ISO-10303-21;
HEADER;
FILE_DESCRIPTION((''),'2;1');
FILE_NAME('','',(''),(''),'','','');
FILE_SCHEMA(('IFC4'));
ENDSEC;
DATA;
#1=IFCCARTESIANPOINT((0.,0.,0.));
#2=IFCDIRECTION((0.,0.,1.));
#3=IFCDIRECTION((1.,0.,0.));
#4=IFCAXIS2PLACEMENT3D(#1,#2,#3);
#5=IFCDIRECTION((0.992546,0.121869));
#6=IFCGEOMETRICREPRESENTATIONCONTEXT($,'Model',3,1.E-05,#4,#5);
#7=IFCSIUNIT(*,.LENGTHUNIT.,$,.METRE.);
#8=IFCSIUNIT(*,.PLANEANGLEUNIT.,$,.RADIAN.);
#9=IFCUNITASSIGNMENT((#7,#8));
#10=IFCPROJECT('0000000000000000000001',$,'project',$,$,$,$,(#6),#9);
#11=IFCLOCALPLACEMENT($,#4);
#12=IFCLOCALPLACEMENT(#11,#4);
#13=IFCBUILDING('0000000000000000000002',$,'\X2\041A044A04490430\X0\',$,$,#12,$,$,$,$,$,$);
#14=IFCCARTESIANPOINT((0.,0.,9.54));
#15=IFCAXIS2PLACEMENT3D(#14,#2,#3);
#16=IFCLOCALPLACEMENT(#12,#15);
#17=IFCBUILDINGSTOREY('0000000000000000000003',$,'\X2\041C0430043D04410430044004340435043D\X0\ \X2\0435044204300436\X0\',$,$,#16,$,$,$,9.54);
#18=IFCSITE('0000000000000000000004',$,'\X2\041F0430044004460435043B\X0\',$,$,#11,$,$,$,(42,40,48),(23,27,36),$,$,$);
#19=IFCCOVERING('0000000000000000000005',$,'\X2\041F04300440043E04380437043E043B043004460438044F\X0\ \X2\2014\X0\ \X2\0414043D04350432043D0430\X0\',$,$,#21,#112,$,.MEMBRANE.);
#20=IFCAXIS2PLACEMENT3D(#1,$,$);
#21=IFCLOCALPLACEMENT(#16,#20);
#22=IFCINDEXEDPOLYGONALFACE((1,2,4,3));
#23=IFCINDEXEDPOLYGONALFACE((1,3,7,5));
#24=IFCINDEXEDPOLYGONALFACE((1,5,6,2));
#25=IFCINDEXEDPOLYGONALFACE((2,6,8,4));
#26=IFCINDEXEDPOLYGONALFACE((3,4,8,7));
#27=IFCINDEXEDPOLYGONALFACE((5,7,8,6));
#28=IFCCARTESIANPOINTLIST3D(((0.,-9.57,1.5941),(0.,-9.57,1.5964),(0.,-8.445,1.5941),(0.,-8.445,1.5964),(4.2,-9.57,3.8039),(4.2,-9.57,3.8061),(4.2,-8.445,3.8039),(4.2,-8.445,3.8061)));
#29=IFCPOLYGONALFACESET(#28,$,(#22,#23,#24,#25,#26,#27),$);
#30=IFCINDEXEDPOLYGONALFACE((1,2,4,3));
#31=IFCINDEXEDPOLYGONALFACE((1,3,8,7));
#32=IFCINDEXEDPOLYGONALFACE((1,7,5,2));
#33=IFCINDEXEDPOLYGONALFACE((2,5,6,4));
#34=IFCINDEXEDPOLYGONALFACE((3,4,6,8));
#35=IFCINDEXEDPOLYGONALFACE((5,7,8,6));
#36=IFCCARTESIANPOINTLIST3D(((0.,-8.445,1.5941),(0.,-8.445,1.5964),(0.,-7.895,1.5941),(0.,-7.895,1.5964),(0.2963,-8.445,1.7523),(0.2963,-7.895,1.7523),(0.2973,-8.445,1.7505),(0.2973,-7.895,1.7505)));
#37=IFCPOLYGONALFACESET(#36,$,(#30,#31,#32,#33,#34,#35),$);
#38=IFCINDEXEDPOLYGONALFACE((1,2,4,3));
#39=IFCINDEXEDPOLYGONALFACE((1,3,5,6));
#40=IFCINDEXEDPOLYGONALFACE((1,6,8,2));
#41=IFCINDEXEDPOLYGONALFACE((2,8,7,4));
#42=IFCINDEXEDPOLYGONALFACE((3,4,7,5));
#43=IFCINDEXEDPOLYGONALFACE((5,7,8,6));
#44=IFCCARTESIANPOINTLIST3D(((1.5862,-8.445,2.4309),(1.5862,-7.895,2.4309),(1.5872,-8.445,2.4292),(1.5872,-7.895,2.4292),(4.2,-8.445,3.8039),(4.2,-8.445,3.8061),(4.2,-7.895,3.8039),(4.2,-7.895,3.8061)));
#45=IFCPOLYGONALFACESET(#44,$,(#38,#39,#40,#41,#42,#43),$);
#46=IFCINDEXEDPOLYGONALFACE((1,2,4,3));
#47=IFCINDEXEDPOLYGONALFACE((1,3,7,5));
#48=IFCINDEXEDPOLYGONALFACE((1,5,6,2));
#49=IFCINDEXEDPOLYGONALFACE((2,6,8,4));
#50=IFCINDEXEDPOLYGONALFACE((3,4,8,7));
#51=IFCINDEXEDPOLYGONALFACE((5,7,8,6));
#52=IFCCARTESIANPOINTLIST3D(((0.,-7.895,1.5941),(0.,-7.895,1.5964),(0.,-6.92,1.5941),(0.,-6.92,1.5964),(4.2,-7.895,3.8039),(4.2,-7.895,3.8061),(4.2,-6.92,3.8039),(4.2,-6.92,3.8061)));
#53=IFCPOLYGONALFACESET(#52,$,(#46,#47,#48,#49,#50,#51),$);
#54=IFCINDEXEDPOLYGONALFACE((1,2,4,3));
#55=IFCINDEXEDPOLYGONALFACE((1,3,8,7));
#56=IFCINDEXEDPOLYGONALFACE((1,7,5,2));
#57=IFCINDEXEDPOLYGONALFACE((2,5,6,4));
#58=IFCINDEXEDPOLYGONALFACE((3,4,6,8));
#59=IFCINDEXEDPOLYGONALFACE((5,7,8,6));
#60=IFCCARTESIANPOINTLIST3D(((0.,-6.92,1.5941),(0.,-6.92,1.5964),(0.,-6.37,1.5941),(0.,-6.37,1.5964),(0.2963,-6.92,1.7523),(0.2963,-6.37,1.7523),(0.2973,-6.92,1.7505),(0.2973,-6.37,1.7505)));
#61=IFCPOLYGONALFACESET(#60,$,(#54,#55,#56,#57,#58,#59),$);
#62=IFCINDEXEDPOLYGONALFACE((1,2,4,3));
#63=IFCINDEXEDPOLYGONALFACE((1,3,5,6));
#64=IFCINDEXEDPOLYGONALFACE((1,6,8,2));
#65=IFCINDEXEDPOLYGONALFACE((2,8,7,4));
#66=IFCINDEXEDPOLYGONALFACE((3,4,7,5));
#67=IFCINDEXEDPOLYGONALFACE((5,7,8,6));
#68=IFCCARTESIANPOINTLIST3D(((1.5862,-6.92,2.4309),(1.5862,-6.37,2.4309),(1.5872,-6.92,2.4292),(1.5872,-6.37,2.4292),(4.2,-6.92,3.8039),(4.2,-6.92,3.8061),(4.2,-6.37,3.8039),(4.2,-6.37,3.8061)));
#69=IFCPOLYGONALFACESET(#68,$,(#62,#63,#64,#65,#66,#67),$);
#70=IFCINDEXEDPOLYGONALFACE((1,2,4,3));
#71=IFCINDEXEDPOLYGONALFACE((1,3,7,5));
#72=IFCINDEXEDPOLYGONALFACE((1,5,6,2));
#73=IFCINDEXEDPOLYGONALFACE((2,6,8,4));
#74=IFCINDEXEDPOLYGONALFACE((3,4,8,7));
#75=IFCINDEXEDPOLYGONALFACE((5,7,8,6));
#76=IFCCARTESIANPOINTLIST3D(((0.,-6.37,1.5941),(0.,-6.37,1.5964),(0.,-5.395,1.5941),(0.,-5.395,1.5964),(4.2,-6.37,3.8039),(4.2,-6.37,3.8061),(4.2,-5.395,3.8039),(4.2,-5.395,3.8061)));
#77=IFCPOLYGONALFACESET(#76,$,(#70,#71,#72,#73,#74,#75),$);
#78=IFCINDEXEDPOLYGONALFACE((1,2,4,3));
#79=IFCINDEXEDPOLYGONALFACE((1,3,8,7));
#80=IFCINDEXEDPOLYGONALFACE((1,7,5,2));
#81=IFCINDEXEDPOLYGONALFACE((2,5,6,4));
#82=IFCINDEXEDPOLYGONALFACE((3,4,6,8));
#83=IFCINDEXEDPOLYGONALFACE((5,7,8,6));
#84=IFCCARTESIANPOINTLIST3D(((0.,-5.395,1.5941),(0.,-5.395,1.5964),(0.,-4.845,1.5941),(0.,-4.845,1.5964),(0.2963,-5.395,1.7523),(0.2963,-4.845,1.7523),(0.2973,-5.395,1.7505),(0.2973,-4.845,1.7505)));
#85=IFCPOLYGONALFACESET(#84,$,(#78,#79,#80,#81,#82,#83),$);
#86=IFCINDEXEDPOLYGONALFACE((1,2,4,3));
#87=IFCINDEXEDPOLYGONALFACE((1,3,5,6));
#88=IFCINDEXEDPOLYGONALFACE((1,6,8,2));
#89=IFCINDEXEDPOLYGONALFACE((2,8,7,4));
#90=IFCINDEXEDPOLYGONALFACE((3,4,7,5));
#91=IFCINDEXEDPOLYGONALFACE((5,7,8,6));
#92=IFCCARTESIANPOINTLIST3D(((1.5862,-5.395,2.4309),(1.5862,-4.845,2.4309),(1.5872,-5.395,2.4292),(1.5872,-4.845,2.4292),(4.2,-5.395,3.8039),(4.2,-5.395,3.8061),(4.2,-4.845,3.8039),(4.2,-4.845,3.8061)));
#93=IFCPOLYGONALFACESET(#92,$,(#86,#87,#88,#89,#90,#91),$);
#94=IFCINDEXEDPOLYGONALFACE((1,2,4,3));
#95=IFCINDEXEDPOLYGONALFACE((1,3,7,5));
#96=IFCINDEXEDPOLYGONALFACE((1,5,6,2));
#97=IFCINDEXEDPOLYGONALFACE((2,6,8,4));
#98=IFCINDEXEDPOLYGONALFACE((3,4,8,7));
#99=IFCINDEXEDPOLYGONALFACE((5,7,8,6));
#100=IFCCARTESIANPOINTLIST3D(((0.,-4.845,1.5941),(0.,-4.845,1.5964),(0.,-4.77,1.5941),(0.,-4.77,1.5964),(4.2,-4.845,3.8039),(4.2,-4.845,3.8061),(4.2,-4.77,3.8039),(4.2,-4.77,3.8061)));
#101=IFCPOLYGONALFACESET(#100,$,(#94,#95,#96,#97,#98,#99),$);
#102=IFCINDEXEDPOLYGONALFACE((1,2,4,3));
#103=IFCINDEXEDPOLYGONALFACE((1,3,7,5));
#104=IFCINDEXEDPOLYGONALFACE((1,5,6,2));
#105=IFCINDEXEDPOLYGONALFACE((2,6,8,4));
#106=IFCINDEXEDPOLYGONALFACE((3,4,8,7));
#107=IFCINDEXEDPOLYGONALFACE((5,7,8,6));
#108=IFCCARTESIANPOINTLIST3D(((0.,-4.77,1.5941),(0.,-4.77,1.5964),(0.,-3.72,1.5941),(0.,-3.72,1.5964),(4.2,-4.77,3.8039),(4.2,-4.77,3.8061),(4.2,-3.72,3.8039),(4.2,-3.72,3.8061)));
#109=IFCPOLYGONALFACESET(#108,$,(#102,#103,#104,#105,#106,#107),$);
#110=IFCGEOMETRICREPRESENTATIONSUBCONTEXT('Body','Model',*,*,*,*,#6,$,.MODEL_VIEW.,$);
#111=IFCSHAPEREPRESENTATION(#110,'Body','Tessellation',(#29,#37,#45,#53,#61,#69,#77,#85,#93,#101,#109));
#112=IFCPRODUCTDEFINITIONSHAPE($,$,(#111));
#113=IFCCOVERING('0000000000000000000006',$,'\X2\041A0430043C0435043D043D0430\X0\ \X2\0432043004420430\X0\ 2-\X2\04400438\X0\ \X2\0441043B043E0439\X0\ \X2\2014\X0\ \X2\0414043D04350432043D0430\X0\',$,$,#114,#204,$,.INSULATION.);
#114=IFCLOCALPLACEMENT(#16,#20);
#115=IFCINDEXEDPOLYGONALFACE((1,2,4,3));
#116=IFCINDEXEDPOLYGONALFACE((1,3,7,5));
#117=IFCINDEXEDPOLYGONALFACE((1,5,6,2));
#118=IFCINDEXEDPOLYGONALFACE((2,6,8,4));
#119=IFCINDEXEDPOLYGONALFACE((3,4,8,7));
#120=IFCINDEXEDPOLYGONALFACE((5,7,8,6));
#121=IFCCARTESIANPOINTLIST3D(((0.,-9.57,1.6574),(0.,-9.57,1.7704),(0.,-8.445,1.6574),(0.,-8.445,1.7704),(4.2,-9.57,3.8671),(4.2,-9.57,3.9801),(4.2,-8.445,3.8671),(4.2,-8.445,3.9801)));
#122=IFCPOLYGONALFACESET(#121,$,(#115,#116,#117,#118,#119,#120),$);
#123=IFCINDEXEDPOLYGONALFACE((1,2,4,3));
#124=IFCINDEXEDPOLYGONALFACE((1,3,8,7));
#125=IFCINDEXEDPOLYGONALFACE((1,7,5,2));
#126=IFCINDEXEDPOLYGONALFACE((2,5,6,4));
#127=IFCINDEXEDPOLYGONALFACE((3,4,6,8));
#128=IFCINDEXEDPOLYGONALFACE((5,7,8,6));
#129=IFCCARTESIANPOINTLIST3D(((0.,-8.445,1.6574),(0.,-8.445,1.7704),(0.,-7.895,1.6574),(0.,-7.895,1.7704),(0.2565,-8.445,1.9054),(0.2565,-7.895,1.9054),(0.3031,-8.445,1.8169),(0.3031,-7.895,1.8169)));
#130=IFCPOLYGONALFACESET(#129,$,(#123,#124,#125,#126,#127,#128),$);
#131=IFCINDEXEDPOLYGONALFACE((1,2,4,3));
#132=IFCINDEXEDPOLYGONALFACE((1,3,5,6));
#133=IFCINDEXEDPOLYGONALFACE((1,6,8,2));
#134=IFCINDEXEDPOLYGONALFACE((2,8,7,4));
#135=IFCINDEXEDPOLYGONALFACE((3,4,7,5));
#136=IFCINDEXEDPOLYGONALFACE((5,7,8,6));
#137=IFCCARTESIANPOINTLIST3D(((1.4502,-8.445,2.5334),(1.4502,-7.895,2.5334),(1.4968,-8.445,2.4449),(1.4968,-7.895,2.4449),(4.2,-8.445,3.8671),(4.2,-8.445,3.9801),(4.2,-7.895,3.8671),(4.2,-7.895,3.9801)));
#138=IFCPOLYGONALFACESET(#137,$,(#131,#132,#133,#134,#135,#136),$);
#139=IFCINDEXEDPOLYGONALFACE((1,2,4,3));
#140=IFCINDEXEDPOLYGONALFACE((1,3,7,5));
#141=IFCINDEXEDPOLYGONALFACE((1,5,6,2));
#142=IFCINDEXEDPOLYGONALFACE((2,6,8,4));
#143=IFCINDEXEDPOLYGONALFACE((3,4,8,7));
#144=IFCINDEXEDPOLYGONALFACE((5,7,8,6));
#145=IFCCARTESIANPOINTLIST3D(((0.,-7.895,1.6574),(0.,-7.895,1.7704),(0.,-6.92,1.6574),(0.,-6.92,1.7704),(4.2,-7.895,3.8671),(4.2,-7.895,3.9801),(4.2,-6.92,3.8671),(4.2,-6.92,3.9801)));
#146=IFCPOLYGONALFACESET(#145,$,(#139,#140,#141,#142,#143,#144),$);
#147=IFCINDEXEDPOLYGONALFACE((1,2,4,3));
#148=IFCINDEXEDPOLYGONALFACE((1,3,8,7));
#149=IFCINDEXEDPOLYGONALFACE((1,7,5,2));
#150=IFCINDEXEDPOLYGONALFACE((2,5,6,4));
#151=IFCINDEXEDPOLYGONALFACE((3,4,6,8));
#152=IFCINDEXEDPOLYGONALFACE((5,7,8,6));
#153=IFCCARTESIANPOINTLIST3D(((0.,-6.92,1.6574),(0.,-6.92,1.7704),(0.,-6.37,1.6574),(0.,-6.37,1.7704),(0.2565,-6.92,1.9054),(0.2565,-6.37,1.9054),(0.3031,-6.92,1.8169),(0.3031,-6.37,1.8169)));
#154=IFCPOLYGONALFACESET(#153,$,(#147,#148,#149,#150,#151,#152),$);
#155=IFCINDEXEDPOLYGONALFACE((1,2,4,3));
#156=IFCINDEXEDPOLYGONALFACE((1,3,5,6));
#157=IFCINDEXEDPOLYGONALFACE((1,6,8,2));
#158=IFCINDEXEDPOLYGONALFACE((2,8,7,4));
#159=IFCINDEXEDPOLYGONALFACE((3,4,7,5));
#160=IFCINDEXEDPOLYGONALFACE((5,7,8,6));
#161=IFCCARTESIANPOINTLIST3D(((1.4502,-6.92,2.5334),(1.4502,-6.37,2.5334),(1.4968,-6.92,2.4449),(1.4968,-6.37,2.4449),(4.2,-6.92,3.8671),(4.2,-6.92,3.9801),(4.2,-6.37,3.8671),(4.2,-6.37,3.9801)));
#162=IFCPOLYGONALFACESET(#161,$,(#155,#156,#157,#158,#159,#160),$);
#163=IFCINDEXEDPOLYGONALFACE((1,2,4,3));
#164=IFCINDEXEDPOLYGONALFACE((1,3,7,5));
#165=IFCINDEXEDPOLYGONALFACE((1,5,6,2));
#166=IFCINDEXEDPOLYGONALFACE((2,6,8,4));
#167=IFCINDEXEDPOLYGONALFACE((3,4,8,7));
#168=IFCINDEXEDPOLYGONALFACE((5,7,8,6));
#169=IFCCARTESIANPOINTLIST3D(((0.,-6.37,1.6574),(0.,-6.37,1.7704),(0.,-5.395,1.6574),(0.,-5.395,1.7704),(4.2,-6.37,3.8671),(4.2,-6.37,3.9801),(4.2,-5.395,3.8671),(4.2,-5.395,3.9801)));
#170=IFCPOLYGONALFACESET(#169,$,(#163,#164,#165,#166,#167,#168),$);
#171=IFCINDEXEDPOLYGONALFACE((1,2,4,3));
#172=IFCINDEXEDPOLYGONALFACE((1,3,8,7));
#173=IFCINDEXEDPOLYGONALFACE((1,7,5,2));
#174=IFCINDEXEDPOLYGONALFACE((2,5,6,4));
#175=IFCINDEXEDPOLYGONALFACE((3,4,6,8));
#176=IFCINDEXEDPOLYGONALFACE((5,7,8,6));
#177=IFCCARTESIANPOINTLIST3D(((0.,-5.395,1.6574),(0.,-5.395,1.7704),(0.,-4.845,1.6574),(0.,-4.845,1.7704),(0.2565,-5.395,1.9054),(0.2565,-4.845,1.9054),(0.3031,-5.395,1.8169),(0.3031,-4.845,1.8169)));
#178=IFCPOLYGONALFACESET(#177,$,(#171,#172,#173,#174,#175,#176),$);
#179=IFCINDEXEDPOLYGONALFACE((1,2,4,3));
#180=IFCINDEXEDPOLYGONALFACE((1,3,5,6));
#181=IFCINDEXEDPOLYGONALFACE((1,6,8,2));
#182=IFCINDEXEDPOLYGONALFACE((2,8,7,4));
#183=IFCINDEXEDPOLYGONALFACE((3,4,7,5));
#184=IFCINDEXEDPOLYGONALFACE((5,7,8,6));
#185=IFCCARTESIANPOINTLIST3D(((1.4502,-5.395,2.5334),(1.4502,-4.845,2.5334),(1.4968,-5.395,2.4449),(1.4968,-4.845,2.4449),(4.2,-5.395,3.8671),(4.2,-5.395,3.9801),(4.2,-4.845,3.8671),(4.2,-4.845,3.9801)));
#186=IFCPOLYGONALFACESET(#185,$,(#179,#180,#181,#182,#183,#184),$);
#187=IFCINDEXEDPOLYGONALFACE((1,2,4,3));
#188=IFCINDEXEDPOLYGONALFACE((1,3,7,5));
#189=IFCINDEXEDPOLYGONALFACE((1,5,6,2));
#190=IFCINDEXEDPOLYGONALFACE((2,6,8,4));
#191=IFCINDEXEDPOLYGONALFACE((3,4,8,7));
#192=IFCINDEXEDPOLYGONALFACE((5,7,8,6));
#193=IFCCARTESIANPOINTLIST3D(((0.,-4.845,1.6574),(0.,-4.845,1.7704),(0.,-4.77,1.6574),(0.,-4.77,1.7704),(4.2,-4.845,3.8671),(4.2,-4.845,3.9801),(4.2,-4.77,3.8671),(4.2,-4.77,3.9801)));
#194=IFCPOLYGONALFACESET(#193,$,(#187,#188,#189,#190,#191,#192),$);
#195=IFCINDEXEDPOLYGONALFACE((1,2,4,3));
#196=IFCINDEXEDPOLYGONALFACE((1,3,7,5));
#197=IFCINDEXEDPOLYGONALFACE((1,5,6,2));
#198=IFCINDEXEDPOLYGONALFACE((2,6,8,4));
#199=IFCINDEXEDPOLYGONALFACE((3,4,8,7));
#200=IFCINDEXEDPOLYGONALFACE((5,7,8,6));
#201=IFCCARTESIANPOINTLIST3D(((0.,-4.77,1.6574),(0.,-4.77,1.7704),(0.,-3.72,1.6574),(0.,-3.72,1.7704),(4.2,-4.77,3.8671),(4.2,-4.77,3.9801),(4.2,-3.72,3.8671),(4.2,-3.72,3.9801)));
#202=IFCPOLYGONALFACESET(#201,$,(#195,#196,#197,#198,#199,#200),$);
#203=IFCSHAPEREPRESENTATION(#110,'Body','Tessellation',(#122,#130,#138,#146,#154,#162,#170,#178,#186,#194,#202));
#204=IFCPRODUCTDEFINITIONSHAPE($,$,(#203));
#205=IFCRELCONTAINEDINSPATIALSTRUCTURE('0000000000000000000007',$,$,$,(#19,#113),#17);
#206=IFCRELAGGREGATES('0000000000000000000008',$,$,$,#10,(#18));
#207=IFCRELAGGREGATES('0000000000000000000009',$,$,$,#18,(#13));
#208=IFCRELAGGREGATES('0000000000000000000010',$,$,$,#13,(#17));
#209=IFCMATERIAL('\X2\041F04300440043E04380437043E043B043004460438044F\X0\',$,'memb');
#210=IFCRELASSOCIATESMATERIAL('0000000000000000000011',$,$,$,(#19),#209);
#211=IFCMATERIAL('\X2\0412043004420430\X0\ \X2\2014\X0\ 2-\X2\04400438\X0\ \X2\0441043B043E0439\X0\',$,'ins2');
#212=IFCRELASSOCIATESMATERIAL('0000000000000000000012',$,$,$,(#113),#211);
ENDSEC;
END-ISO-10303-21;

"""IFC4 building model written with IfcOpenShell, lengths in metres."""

from ifc_helpers import new_model, si_unit, direction, frame, origin_with_axes, place, context, subcontext, project, spatial, polyline, outline, extrude, material, element, save


model = new_model("IFC4")

# Units and contexts
model_context = context("Model", 3, precision=1e-05, world=origin_with_axes(), true_north=direction((0.992546, 0.121869)))
body_context = subcontext(model_context, "Body", "Model", "MODEL_VIEW")
ifc_project = project(units=[si_unit("LENGTHUNIT", "METRE"), si_unit("PLANEANGLEUNIT", "RADIAN")], contexts=[model_context])

# Site, building, storey
site_placement = place(None, origin_with_axes())
site = spatial("IfcSite", under=ifc_project, at=site_placement, Name="Парцел", RefLatitude=(42, 40, 48), RefLongitude=(23, 27, 36))
building_placement = place(site_placement, origin_with_axes())
building = spatial("IfcBuilding", under=site, at=building_placement, Name="Къща")
storey_placement = place(building_placement, frame((0.0, 0.0, 9.54), z_axis=(0.0, 0.0, 1.0), x_axis=(1.0, 0.0, 0.0)))
storey = spatial("IfcBuildingStorey", under=building, at=storey_placement, Name="Мансарден етаж", Elevation=9.54)

# Coverings
ifc_material_1 = material(Name="Пароизолация", Category="memb")
covering_1_placement = place(storey_placement, origin_with_axes())
element("IfcCovering", 1, at=covering_1_placement, inside=storey, material=ifc_material_1, Name="Пароизолация — Дневна", PredefinedType="MEMBRANE", context=body_context, shape_type="SweptSolid", body=[
    extrude(outline(polyline([(0.0, -1.5941), (4.2, -3.8039), (4.2, -3.8061), (0.0, -1.5964), (0.0, -1.5941)])), frame((0.0, -9.57, 0.0), z_axis=(0.0, 1.0, 0.0), x_axis=(1.0, 0.0, 0.0)), (0.0, 0.0, 1.0), 1.125),
    extrude(outline(polyline([(0.0, -1.5941), (0.2973, -1.7505), (0.2963, -1.7523), (0.0, -1.5964), (0.0, -1.5941)])), frame((0.0, -8.445, 0.0), z_axis=(0.0, 1.0, 0.0), x_axis=(1.0, 0.0, 0.0)), (0.0, 0.0, 1.0), 0.55),
    extrude(outline(polyline([(1.5872, -2.4292), (4.2, -3.8039), (4.2, -3.8061), (1.5862, -2.4309), (1.5872, -2.4292)])), frame((0.0, -8.445, 0.0), z_axis=(0.0, 1.0, 0.0), x_axis=(1.0, 0.0, 0.0)), (0.0, 0.0, 1.0), 0.55),
    extrude(outline(polyline([(0.0, -1.5941), (4.2, -3.8039), (4.2, -3.8061), (0.0, -1.5964), (0.0, -1.5941)])), frame((0.0, -7.895, 0.0), z_axis=(0.0, 1.0, 0.0), x_axis=(1.0, 0.0, 0.0)), (0.0, 0.0, 1.0), 0.975),
    extrude(outline(polyline([(0.0, -1.5941), (0.2973, -1.7505), (0.2963, -1.7523), (0.0, -1.5964), (0.0, -1.5941)])), frame((0.0, -6.92, 0.0), z_axis=(0.0, 1.0, 0.0), x_axis=(1.0, 0.0, 0.0)), (0.0, 0.0, 1.0), 0.55),
    extrude(outline(polyline([(1.5872, -2.4292), (4.2, -3.8039), (4.2, -3.8061), (1.5862, -2.4309), (1.5872, -2.4292)])), frame((0.0, -6.92, 0.0), z_axis=(0.0, 1.0, 0.0), x_axis=(1.0, 0.0, 0.0)), (0.0, 0.0, 1.0), 0.55),
    extrude(outline(polyline([(0.0, -1.5941), (4.2, -3.8039), (4.2, -3.8061), (0.0, -1.5964), (0.0, -1.5941)])), frame((0.0, -6.37, 0.0), z_axis=(0.0, 1.0, 0.0), x_axis=(1.0, 0.0, 0.0)), (0.0, 0.0, 1.0), 0.975),
    extrude(outline(polyline([(0.0, -1.5941), (0.2973, -1.7505), (0.2963, -1.7523), (0.0, -1.5964), (0.0, -1.5941)])), frame((0.0, -5.395, 0.0), z_axis=(0.0, 1.0, 0.0), x_axis=(1.0, 0.0, 0.0)), (0.0, 0.0, 1.0), 0.55),
    extrude(outline(polyline([(1.5872, -2.4292), (4.2, -3.8039), (4.2, -3.8061), (1.5862, -2.4309), (1.5872, -2.4292)])), frame((0.0, -5.395, 0.0), z_axis=(0.0, 1.0, 0.0), x_axis=(1.0, 0.0, 0.0)), (0.0, 0.0, 1.0), 0.55),
    extrude(outline(polyline([(0.0, -1.5941), (4.2, -3.8039), (4.2, -3.8061), (0.0, -1.5964), (0.0, -1.5941)])), frame((0.0, -4.845, 0.0), z_axis=(0.0, 1.0, 0.0), x_axis=(1.0, 0.0, 0.0)), (0.0, 0.0, 1.0), 0.075),
    extrude(outline(polyline([(0.0, -1.5941), (4.2, -3.8039), (4.2, -3.8061), (0.0, -1.5964), (0.0, -1.5941)])), frame((0.0, -4.77, 0.0), z_axis=(0.0, 1.0, 0.0), x_axis=(1.0, 0.0, 0.0)), (0.0, 0.0, 1.0), 1.05),
])
ifc_material_2 = material(Name="Вата — 2-ри слой", Category="ins2")
covering_2_placement = place(storey_placement, origin_with_axes())
element("IfcCovering", 2, at=covering_2_placement, inside=storey, material=ifc_material_2, Name="Каменна вата 2-ри слой — Дневна", PredefinedType="INSULATION", context=body_context, shape_type="SweptSolid", body=[
    extrude(outline(polyline([(0.0, -1.6574), (4.2, -3.8671), (4.2, -3.9801), (0.0, -1.7704), (0.0, -1.6574)])), frame((0.0, -9.57, 0.0), z_axis=(0.0, 1.0, 0.0), x_axis=(1.0, 0.0, 0.0)), (0.0, 0.0, 1.0), 1.125),
    extrude(outline(polyline([(0.0, -1.6574), (0.3031, -1.8169), (0.2565, -1.9054), (0.0, -1.7704), (0.0, -1.6574)])), frame((0.0, -8.445, 0.0), z_axis=(0.0, 1.0, 0.0), x_axis=(1.0, 0.0, 0.0)), (0.0, 0.0, 1.0), 0.55),
    extrude(outline(polyline([(1.4968, -2.4449), (4.2, -3.8671), (4.2, -3.9801), (1.4502, -2.5334), (1.4968, -2.4449)])), frame((0.0, -8.445, 0.0), z_axis=(0.0, 1.0, 0.0), x_axis=(1.0, 0.0, 0.0)), (0.0, 0.0, 1.0), 0.55),
    extrude(outline(polyline([(0.0, -1.6574), (4.2, -3.8671), (4.2, -3.9801), (0.0, -1.7704), (0.0, -1.6574)])), frame((0.0, -7.895, 0.0), z_axis=(0.0, 1.0, 0.0), x_axis=(1.0, 0.0, 0.0)), (0.0, 0.0, 1.0), 0.975),
    extrude(outline(polyline([(0.0, -1.6574), (0.3031, -1.8169), (0.2565, -1.9054), (0.0, -1.7704), (0.0, -1.6574)])), frame((0.0, -6.92, 0.0), z_axis=(0.0, 1.0, 0.0), x_axis=(1.0, 0.0, 0.0)), (0.0, 0.0, 1.0), 0.55),
    extrude(outline(polyline([(1.4968, -2.4449), (4.2, -3.8671), (4.2, -3.9801), (1.4502, -2.5334), (1.4968, -2.4449)])), frame((0.0, -6.92, 0.0), z_axis=(0.0, 1.0, 0.0), x_axis=(1.0, 0.0, 0.0)), (0.0, 0.0, 1.0), 0.55),
    extrude(outline(polyline([(0.0, -1.6574), (4.2, -3.8671), (4.2, -3.9801), (0.0, -1.7704), (0.0, -1.6574)])), frame((0.0, -6.37, 0.0), z_axis=(0.0, 1.0, 0.0), x_axis=(1.0, 0.0, 0.0)), (0.0, 0.0, 1.0), 0.975),
    extrude(outline(polyline([(0.0, -1.6574), (0.3031, -1.8169), (0.2565, -1.9054), (0.0, -1.7704), (0.0, -1.6574)])), frame((0.0, -5.395, 0.0), z_axis=(0.0, 1.0, 0.0), x_axis=(1.0, 0.0, 0.0)), (0.0, 0.0, 1.0), 0.55),
    extrude(outline(polyline([(1.4968, -2.4449), (4.2, -3.8671), (4.2, -3.9801), (1.4502, -2.5334), (1.4968, -2.4449)])), frame((0.0, -5.395, 0.0), z_axis=(0.0, 1.0, 0.0), x_axis=(1.0, 0.0, 0.0)), (0.0, 0.0, 1.0), 0.55),
    extrude(outline(polyline([(0.0, -1.6574), (4.2, -3.8671), (4.2, -3.9801), (0.0, -1.7704), (0.0, -1.6574)])), frame((0.0, -4.845, 0.0), z_axis=(0.0, 1.0, 0.0), x_axis=(1.0, 0.0, 0.0)), (0.0, 0.0, 1.0), 0.075),
    extrude(outline(polyline([(0.0, -1.6574), (4.2, -3.8671), (4.2, -3.9801), (0.0, -1.7704), (0.0, -1.6574)])), frame((0.0, -4.77, 0.0), z_axis=(0.0, 1.0, 0.0), x_axis=(1.0, 0.0, 0.0)), (0.0, 0.0, 1.0), 1.05),
])

save(model, "model.ifc")
